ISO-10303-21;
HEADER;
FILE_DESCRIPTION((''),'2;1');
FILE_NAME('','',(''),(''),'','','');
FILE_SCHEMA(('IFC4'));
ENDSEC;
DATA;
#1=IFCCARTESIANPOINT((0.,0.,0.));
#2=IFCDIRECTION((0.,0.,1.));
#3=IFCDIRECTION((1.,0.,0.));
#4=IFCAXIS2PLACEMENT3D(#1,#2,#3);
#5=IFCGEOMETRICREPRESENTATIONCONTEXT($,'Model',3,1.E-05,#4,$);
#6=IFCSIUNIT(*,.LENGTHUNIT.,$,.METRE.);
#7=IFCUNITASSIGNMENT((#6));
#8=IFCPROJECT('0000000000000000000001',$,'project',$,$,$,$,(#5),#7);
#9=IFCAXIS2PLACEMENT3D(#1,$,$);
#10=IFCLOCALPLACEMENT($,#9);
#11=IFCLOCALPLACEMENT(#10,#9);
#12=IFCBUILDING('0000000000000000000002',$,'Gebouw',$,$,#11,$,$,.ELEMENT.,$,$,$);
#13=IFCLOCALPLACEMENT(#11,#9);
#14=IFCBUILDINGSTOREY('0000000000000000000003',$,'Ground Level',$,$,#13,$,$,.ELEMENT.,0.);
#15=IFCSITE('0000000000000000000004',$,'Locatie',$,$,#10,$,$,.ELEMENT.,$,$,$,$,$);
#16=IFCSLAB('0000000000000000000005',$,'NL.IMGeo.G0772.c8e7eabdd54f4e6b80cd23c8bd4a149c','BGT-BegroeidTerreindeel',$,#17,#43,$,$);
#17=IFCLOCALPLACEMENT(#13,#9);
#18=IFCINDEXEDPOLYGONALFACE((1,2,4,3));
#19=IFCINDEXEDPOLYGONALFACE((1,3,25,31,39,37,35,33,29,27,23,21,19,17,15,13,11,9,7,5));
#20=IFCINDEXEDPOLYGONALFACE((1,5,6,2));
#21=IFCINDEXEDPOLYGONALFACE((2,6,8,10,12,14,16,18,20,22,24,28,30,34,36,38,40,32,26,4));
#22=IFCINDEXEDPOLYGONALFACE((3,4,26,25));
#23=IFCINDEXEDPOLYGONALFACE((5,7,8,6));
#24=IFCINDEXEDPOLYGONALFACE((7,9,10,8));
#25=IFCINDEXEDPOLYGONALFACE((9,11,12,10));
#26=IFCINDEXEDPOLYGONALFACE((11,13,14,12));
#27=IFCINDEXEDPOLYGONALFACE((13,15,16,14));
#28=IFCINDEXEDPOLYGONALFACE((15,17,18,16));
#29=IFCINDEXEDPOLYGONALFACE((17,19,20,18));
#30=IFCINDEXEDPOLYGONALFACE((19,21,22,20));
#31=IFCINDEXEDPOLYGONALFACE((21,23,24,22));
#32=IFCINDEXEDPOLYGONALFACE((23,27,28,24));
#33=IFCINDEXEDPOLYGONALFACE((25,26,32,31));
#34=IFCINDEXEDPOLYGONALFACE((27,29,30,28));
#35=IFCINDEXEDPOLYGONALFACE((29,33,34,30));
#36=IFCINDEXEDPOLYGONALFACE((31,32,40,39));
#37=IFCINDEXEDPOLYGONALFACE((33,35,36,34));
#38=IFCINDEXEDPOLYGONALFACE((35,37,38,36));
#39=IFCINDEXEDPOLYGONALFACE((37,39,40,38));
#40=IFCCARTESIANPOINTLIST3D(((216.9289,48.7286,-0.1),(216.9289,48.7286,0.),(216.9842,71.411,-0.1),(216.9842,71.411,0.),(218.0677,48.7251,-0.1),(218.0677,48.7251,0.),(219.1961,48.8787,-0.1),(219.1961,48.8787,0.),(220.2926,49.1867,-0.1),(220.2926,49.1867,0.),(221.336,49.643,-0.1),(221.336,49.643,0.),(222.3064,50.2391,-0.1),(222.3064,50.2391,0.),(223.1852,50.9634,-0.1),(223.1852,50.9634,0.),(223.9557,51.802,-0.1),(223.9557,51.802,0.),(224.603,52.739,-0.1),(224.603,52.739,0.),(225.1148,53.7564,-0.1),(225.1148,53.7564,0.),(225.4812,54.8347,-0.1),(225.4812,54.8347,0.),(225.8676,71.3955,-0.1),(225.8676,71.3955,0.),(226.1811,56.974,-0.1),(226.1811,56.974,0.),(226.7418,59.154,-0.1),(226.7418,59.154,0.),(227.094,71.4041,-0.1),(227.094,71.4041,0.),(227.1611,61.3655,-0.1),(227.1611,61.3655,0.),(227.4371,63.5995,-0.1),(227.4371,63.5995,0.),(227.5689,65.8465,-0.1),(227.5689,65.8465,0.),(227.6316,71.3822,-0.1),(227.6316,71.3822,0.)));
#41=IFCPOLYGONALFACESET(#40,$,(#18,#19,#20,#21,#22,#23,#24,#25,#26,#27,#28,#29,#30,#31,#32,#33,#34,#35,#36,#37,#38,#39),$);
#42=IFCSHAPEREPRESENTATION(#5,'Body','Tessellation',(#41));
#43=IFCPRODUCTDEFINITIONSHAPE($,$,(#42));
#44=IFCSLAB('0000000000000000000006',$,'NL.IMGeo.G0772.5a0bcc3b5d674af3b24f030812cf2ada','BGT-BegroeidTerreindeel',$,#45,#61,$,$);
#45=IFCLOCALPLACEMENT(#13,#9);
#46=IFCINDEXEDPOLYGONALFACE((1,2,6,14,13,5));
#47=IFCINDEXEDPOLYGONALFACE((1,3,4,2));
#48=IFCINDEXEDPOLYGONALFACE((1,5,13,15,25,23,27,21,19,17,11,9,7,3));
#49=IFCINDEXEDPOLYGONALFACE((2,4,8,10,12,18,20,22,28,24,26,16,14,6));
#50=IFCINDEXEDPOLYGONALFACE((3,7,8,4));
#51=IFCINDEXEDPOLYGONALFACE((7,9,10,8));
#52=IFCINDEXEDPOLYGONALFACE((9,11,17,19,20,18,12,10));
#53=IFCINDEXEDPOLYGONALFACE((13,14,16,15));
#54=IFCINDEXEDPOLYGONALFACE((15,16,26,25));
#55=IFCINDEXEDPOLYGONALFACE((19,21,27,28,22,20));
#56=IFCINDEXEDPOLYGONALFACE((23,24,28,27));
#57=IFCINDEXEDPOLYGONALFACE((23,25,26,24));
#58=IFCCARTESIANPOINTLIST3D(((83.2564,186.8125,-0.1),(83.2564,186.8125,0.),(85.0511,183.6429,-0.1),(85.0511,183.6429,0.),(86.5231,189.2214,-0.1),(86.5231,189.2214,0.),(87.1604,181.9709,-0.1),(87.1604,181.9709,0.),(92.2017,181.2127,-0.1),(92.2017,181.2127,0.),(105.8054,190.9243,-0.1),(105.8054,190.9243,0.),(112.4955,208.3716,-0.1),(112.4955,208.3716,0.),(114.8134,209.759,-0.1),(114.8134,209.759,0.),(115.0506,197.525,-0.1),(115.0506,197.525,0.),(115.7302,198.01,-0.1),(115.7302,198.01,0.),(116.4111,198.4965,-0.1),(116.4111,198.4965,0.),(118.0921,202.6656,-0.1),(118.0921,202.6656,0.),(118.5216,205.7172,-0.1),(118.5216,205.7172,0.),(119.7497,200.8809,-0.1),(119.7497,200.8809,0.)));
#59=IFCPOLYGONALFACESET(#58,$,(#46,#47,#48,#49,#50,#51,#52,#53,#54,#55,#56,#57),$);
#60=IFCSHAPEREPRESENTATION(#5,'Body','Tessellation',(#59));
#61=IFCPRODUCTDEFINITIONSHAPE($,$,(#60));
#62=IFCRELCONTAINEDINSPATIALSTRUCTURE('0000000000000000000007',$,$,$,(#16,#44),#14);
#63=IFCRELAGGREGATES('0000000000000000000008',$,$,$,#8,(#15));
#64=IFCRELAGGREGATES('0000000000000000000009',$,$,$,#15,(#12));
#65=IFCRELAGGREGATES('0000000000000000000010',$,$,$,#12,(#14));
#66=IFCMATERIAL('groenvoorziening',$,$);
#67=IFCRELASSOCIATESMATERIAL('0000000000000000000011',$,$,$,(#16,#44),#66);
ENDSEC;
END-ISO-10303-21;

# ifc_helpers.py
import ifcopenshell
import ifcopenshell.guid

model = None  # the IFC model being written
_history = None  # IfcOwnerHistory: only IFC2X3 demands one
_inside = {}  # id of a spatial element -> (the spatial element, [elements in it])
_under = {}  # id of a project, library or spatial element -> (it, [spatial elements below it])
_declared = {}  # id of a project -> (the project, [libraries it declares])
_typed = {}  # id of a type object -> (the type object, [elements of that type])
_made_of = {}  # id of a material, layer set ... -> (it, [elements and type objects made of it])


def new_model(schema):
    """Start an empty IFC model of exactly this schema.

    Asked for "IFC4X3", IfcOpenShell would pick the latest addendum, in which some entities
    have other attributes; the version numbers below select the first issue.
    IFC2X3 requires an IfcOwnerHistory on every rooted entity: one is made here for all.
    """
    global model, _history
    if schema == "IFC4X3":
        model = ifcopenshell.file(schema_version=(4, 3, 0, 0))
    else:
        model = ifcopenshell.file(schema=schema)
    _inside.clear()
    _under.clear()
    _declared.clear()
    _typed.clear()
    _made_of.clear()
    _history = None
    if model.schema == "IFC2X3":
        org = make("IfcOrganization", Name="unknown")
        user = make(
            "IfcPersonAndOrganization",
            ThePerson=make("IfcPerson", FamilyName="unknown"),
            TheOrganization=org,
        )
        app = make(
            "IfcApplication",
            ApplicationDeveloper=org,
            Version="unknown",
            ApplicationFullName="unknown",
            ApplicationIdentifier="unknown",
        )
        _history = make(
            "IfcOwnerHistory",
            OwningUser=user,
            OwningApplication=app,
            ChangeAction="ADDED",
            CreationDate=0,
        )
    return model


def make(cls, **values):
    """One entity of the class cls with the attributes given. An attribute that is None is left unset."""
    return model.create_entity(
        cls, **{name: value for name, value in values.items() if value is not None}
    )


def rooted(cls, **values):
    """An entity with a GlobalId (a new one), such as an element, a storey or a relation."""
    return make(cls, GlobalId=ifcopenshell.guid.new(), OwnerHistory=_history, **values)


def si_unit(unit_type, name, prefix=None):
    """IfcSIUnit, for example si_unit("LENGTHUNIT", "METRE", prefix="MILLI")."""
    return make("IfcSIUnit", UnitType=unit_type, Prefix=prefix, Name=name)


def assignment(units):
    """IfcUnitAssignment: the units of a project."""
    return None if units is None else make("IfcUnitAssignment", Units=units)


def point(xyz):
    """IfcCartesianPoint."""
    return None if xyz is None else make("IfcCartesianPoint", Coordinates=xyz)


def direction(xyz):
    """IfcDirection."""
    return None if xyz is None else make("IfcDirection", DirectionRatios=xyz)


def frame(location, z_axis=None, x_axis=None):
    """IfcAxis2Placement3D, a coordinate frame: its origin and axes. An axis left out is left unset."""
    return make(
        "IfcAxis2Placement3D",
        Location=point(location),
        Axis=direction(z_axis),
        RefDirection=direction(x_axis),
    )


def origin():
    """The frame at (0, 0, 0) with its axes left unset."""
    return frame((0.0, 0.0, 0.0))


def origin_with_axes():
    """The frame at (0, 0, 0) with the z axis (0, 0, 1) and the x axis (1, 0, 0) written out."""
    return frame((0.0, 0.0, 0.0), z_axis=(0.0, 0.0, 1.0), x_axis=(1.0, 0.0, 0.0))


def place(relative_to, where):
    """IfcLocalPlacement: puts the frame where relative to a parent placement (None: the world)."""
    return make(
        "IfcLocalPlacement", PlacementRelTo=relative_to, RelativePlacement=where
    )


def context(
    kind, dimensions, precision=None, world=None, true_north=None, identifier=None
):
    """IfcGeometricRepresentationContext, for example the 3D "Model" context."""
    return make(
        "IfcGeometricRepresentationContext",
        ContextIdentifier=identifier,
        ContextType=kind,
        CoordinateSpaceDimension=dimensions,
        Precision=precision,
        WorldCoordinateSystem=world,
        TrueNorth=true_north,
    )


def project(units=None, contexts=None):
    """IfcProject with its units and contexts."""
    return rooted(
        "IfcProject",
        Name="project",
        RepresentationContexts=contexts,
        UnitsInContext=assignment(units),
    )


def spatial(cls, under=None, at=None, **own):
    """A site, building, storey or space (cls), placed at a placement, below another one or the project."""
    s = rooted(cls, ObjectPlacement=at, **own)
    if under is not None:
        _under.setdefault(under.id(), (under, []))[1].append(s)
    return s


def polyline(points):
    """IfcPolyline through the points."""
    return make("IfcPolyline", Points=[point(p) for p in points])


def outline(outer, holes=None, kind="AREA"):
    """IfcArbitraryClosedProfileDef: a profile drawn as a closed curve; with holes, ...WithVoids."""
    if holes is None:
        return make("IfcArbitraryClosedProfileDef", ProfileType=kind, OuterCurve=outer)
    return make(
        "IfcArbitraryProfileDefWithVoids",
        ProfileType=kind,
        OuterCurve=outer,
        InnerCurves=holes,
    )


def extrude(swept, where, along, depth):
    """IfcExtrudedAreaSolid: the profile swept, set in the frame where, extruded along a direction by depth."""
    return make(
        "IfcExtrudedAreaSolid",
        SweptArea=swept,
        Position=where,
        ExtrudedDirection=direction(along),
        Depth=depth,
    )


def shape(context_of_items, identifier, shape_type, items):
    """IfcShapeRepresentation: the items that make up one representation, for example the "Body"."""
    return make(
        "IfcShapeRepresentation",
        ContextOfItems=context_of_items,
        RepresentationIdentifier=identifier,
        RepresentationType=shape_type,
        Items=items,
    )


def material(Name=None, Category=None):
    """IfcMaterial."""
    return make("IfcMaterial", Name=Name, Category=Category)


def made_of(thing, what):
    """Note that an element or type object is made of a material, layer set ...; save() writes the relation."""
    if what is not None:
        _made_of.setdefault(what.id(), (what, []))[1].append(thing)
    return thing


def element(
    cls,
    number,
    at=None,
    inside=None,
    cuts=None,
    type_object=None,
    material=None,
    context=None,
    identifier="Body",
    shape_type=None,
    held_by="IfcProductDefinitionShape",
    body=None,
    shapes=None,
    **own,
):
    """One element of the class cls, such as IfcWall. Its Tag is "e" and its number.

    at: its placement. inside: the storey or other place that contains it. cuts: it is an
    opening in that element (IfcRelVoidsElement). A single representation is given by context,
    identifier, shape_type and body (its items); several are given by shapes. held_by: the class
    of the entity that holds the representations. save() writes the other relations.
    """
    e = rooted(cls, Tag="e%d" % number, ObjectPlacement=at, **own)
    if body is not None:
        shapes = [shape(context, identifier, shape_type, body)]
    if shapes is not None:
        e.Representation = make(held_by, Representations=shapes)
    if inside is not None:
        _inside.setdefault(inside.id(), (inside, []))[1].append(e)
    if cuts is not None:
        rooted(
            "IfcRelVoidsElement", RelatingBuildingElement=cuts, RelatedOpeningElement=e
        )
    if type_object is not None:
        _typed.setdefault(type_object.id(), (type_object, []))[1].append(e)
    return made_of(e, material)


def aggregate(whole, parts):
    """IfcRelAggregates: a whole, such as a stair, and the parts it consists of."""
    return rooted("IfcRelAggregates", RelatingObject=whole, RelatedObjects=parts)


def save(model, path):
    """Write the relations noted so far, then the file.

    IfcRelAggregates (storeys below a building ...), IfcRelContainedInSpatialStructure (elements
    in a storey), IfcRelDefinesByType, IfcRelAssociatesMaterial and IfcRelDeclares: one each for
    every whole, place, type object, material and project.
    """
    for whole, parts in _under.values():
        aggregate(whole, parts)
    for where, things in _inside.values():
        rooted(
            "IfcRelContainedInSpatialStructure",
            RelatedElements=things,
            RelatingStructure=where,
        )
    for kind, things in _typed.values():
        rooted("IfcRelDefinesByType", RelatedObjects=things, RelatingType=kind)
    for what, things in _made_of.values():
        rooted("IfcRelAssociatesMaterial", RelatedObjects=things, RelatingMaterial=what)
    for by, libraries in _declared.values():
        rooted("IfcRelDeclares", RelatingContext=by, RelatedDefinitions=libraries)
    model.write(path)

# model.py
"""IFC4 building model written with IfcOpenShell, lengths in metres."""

from ifc_helpers import new_model, si_unit, frame, origin, origin_with_axes, place, context, project, spatial, polyline, outline, extrude, material, element, save


model = new_model("IFC4")

# Units and contexts
model_context = context("Model", 3, precision=1e-05, world=origin_with_axes())
ifc_project = project(units=[si_unit("LENGTHUNIT", "METRE")], contexts=[model_context])

# Site, building, storey
site_placement = place(None, origin())
site = spatial("IfcSite", under=ifc_project, at=site_placement, Name="Locatie", CompositionType="ELEMENT")
building_placement = place(site_placement, origin())
building = spatial("IfcBuilding", under=site, at=building_placement, Name="Gebouw", CompositionType="ELEMENT")
storey_placement = place(building_placement, origin())
storey = spatial("IfcBuildingStorey", under=building, at=storey_placement, Name="Ground Level", CompositionType="ELEMENT", Elevation=0.0)

# Slabs
ifc_material = material(Name="groenvoorziening")
slab_1_placement = place(storey_placement, origin())
element("IfcSlab", 1, at=slab_1_placement, inside=storey, material=ifc_material, Name="NL.IMGeo.G0772.c8e7eabdd54f4e6b80cd23c8bd4a149c", Description="BGT-BegroeidTerreindeel", context=model_context, shape_type="SweptSolid", body=[
    extrude(outline(polyline([(227.6316, 71.3822), (227.5689, 65.8465), (227.4371, 63.5995), (227.1611, 61.3655), (226.7418, 59.154), (226.1811, 56.974), (225.4812, 54.8347), (225.1148, 53.7564), (224.603, 52.739), (223.9557, 51.802), (223.1852, 50.9634), (222.3064, 50.2391), (221.336, 49.643), (220.2926, 49.1867), (219.1961, 48.8787), (218.0677, 48.7251), (216.9289, 48.7286), (216.9842, 71.411), (225.8676, 71.3955), (227.094, 71.4041), (227.6316, 71.3822)])), frame((0.0, 0.0, -0.1), z_axis=(0.0, 0.0, 1.0), x_axis=(1.0, 0.0, 0.0)), (0.0, 0.0, 1.0), 0.1),
])
slab_2_placement = place(storey_placement, origin())
element("IfcSlab", 2, at=slab_2_placement, inside=storey, material=ifc_material, Name="NL.IMGeo.G0772.5a0bcc3b5d674af3b24f030812cf2ada", Description="BGT-BegroeidTerreindeel", context=model_context, shape_type="SweptSolid", body=[
    extrude(outline(polyline([(118.5216, 205.7172), (118.0921, 202.6656), (119.7497, 200.8809), (116.4111, 198.4965), (115.7302, 198.01), (115.0506, 197.525), (105.8054, 190.9243), (92.2017, 181.2127), (87.1604, 181.9709), (85.0511, 183.6429), (83.2564, 186.8125), (86.5231, 189.2214), (112.4955, 208.3716), (114.8134, 209.759), (118.5216, 205.7172)])), frame((0.0, 0.0, -0.1), z_axis=(0.0, 0.0, 1.0), x_axis=(1.0, 0.0, 0.0)), (0.0, 0.0, 1.0), 0.1),
])

save(model, "model.ifc")
